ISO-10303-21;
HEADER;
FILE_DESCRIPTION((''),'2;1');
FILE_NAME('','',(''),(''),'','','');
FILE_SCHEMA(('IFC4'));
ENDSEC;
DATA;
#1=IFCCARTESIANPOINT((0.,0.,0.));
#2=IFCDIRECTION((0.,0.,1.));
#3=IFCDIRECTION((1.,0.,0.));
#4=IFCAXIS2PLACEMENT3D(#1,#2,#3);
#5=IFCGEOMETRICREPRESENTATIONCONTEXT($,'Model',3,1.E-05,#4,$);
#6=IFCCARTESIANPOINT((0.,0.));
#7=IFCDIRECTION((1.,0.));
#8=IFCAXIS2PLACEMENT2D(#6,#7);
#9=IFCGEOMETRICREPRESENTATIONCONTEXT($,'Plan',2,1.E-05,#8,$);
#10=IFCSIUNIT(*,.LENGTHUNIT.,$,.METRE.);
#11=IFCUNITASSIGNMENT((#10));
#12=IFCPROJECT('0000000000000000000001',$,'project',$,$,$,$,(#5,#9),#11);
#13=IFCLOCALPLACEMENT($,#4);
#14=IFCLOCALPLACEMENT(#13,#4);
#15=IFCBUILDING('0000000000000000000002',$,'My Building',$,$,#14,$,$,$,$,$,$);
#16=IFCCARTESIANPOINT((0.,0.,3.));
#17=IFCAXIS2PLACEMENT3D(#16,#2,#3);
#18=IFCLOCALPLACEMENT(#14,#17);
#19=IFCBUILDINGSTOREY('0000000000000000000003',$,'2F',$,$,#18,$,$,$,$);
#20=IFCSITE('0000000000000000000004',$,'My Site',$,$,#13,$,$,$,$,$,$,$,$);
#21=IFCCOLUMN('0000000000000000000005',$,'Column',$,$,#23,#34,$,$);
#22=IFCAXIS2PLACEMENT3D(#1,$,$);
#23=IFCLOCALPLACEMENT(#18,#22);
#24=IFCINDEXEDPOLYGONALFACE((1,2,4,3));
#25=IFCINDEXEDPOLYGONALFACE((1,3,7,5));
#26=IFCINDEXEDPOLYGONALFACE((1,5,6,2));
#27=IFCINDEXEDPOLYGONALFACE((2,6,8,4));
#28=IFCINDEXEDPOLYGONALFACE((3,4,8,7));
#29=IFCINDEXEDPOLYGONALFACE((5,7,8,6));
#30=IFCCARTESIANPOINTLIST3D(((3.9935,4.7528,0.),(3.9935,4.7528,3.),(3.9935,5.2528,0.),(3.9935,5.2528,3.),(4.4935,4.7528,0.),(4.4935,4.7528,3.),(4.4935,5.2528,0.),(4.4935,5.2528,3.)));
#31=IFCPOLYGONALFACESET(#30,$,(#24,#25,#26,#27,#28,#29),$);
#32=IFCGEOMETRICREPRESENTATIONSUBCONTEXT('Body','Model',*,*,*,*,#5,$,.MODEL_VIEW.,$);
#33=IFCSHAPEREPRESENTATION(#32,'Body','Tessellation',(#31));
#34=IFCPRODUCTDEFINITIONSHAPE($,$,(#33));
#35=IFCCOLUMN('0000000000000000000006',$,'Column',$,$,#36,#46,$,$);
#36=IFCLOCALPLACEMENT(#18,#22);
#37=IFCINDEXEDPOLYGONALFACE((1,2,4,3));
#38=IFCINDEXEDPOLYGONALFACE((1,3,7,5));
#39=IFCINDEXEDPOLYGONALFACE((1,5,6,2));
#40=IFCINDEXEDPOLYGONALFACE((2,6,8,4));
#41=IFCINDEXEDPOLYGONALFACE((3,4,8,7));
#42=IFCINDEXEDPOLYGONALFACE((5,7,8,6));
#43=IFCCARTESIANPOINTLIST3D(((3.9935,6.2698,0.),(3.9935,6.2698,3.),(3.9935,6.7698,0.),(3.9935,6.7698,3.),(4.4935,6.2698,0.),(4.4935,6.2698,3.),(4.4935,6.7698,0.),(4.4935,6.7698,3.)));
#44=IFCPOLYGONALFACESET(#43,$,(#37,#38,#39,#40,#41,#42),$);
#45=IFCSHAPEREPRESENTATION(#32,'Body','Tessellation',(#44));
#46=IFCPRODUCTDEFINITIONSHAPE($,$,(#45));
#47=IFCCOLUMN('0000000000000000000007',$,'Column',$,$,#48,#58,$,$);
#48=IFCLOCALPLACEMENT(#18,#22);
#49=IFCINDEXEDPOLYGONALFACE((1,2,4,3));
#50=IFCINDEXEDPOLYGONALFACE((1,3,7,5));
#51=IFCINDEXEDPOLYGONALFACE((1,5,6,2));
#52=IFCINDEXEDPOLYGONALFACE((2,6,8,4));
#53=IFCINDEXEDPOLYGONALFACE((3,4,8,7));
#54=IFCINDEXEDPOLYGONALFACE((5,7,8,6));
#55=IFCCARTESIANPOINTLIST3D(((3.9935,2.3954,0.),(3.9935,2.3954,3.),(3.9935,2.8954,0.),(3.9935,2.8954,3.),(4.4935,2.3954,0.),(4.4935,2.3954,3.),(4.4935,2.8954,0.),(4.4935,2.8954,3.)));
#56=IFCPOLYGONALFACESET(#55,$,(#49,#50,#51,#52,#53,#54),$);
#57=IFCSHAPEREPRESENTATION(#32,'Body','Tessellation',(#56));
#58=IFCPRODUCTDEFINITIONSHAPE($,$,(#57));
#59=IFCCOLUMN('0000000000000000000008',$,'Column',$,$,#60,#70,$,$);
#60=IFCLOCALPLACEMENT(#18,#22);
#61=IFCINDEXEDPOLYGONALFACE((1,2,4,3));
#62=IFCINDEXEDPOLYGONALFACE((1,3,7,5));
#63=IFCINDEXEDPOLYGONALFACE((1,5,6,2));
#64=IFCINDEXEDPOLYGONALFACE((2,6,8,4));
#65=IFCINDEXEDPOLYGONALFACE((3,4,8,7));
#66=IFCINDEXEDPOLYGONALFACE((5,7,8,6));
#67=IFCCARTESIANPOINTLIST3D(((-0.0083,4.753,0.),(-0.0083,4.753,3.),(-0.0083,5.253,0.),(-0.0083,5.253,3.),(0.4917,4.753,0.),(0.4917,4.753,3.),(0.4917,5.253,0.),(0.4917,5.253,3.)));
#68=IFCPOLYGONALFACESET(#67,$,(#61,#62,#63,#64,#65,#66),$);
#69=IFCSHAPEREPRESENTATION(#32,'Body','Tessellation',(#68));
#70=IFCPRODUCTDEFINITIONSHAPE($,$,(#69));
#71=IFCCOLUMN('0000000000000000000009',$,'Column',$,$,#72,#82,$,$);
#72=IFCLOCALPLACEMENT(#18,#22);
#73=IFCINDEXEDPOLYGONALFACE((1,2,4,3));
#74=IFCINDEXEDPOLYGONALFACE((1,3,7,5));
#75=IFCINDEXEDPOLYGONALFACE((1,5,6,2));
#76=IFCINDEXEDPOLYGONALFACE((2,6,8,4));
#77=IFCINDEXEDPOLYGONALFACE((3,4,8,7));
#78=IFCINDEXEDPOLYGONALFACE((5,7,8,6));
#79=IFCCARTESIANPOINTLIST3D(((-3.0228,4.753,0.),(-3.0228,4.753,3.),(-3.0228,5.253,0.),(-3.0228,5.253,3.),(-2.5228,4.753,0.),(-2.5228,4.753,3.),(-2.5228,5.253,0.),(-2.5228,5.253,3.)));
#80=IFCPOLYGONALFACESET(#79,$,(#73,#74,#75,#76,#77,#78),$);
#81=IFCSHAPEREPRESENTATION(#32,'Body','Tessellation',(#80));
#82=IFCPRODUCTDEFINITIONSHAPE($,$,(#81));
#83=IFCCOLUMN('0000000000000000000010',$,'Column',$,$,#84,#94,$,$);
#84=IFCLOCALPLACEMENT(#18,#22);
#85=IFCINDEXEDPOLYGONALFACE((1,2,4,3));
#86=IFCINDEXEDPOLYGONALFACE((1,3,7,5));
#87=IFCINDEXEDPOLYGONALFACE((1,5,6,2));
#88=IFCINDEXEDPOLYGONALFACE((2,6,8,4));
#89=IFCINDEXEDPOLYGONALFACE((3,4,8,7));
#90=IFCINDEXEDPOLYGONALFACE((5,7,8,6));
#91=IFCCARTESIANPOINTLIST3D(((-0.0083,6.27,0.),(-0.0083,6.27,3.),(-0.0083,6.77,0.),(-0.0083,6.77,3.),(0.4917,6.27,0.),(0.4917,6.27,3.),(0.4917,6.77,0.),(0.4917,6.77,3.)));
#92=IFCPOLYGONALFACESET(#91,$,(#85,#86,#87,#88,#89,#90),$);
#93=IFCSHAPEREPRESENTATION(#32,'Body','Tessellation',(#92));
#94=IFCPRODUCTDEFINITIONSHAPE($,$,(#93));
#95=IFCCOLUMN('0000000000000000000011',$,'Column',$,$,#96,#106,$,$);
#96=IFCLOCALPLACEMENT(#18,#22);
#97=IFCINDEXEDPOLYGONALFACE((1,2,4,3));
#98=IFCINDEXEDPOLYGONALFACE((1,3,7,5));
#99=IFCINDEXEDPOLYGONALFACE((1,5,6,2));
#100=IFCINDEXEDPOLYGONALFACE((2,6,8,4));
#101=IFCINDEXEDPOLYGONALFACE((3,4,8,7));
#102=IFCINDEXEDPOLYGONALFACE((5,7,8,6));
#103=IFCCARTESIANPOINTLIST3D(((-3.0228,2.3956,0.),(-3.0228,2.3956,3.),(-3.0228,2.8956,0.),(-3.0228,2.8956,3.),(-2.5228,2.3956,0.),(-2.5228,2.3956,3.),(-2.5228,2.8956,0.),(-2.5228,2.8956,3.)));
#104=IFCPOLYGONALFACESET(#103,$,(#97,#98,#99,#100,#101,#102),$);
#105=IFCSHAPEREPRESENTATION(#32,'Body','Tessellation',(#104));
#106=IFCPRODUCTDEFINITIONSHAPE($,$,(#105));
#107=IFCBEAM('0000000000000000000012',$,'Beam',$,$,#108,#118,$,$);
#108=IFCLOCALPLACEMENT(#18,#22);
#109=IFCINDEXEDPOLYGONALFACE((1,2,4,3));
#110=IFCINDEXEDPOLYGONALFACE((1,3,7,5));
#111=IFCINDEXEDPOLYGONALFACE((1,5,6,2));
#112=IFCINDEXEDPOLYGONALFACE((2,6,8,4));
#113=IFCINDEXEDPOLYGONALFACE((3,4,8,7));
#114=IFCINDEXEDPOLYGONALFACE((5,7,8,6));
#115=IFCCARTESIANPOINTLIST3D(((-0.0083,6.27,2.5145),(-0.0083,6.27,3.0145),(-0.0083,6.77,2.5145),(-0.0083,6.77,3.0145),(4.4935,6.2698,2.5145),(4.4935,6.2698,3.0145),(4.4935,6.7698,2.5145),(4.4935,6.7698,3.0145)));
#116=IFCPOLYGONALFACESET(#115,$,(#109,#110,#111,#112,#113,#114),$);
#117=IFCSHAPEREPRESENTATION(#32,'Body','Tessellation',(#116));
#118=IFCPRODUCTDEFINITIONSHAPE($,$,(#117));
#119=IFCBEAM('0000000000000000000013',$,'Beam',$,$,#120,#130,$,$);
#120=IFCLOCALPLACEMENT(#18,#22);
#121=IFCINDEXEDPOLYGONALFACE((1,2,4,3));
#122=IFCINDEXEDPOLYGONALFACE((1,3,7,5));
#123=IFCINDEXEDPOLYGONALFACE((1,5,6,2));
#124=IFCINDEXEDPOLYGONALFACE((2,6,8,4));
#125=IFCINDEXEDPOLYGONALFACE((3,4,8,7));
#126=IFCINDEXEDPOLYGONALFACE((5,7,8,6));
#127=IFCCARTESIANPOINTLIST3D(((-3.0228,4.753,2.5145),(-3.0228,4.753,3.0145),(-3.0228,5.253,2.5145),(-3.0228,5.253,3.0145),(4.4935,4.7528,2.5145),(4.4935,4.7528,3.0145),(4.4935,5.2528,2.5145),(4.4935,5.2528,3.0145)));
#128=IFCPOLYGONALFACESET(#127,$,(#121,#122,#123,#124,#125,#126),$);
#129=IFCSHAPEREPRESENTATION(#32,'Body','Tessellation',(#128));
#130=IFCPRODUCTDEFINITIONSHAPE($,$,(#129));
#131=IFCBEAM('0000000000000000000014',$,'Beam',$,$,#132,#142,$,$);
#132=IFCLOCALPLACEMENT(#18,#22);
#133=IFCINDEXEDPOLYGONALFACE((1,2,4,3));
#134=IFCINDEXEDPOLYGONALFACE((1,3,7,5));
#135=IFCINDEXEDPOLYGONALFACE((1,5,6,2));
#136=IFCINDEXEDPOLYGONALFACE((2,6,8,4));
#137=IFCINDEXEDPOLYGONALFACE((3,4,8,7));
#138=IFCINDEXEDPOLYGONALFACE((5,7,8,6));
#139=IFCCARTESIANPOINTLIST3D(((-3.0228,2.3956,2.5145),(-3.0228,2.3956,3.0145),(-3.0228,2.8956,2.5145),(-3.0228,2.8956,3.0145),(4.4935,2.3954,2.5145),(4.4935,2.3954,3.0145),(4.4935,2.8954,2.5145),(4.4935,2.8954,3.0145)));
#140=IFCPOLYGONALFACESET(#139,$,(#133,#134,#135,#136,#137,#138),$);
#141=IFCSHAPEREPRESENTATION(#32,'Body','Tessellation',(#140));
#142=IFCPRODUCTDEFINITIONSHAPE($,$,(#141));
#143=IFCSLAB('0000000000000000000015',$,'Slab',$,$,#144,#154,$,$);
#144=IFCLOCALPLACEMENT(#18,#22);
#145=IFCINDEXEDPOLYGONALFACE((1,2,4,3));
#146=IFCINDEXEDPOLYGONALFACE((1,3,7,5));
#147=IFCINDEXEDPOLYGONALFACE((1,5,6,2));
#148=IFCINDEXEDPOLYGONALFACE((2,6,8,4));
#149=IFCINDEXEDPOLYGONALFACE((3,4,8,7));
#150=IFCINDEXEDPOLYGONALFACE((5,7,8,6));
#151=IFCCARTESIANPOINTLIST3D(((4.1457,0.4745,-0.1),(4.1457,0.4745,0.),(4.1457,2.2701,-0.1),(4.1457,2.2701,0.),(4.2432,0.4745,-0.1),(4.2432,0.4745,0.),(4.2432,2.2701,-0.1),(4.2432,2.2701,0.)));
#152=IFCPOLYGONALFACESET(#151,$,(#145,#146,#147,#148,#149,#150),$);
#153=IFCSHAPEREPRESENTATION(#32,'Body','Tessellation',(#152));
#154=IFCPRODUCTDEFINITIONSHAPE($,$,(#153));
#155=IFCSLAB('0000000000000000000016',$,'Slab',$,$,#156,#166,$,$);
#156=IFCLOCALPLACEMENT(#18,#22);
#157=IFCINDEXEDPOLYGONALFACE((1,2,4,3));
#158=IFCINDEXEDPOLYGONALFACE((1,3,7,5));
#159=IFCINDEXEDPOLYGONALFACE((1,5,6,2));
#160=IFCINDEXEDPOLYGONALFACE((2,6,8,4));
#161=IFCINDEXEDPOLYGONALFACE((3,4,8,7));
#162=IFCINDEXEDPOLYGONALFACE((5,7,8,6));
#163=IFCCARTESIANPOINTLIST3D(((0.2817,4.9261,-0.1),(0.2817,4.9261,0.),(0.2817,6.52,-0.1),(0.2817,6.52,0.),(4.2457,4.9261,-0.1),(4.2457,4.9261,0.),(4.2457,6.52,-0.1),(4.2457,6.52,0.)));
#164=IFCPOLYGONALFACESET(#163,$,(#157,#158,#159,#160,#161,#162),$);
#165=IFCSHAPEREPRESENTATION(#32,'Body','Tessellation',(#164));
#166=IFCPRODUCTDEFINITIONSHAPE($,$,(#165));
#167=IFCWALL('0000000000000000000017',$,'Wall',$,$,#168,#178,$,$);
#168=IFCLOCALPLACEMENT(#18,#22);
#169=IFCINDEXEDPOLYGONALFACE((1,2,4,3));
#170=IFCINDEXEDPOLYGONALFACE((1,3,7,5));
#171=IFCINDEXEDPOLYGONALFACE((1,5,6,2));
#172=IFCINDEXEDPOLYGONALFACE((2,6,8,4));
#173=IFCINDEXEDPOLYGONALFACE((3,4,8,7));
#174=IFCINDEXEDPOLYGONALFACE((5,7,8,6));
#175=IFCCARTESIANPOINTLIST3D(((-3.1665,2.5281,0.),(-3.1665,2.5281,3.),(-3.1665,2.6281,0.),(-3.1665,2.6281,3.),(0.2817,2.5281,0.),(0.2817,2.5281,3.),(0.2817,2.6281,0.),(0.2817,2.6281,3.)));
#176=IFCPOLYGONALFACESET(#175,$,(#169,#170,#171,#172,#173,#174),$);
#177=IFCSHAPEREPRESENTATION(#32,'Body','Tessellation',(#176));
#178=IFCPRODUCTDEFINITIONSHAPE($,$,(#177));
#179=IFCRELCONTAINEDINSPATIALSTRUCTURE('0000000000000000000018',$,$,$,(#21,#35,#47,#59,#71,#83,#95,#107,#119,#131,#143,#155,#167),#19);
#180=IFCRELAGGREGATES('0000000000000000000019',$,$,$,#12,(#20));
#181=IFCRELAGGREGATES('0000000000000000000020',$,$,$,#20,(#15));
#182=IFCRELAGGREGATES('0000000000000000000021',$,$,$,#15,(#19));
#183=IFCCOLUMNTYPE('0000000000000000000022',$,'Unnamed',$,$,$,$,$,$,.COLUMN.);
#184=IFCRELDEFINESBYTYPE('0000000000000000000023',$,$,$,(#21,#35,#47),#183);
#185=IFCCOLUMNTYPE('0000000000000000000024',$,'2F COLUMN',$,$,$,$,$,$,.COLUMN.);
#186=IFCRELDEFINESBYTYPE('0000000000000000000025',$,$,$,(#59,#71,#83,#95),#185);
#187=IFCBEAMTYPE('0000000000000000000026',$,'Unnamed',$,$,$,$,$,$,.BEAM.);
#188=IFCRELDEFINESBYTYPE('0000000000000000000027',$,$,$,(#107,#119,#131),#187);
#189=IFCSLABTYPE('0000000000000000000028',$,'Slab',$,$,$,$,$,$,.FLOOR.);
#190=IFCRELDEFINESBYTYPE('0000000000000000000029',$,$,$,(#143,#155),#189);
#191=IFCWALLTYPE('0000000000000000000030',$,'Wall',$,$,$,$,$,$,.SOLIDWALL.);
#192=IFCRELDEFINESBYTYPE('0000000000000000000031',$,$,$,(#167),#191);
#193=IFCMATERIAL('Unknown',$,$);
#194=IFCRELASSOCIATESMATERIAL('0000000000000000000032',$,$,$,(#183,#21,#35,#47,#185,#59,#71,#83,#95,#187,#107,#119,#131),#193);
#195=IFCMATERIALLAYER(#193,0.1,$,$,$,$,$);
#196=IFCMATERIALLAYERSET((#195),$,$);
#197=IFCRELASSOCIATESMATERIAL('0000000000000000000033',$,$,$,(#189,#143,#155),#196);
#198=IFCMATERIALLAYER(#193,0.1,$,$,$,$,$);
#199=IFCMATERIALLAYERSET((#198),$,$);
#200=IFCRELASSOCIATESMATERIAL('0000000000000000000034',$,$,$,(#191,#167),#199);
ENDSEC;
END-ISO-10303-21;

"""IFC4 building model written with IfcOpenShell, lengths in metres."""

from ifc_helpers import new_model, si_unit, frame, origin_with_axes, origin_2d_with_axis, place, context, subcontext, project, spatial, line, indexed_curve, rectangle, outline, extrude, material, layer, layer_set, layer_usage, material_profile, profile_set, profile_usage, type_object, element, save


model = new_model("IFC4")

# Units and contexts
model_context = context("Model", 3, precision=1e-05, world=origin_with_axes())
plan_context = context("Plan", 2, precision=1e-05, world=origin_2d_with_axis())
body_context_1 = subcontext(model_context, "Body", "Model", "MODEL_VIEW")
ifc_project = project(units=[si_unit("LENGTHUNIT", "METRE")], contexts=[model_context, plan_context])

# Site, building, storey
site_placement = place(None, origin_with_axes())
site = spatial("IfcSite", under=ifc_project, at=site_placement, Name="My Site")
building_placement = place(site_placement, origin_with_axes())
building = spatial("IfcBuilding", under=site, at=building_placement, Name="My Building")
storey_placement = place(building_placement, frame((0.0, 0.0, 3.0), z_axis=(0.0, 0.0, 1.0), x_axis=(1.0, 0.0, 0.0)))
storey = spatial("IfcBuildingStorey", under=building, at=storey_placement, Name="2F")

# Columns
ifc_material = material(Name="Unknown")
ifc_material_profile_1 = material_profile(ifc_material, rectangle(XDim=0.5, YDim=0.5))
ifc_profile_set_1 = profile_set([ifc_material_profile_1])
ifc_profile_usage_1 = profile_usage(ifc_profile_set_1, cardinal=7)
column_type_1 = type_object("IfcColumnType", Name="Unnamed", PredefinedType="COLUMN", material=ifc_profile_set_1)
column_1_placement = place(storey_placement, frame((4.4935, 5.2528, 0.0), z_axis=(0.0, 0.0, 1.0), x_axis=(1.0, 0.0, 0.0)))
element("IfcColumn", 1, at=column_1_placement, inside=storey, type_object=column_type_1, material=ifc_profile_usage_1, Name="Column", context=body_context_1, shape_type="SweptSolid", body=[
    extrude(rectangle(XDim=0.5, YDim=0.5), frame((-0.25, -0.25, 0.0), z_axis=(0.0, 0.0, 1.0), x_axis=(1.0, 0.0, 0.0)), (0.0, 0.0, 1.0), 3.0),
])
ifc_profile_usage_2 = profile_usage(ifc_profile_set_1, cardinal=7)
column_2_placement = place(storey_placement, frame((4.4935, 6.7698, 0.0), z_axis=(0.0, 0.0, 1.0), x_axis=(1.0, 0.0, 0.0)))
element("IfcColumn", 2, at=column_2_placement, inside=storey, type_object=column_type_1, material=ifc_profile_usage_2, Name="Column", context=body_context_1, shape_type="SweptSolid", body=[
    extrude(rectangle(XDim=0.5, YDim=0.5), frame((-0.25, -0.25, 0.0), z_axis=(0.0, 0.0, 1.0), x_axis=(1.0, 0.0, 0.0)), (0.0, 0.0, 1.0), 3.0),
])
ifc_profile_usage_3 = profile_usage(ifc_profile_set_1, cardinal=7)
column_3_placement = place(storey_placement, frame((4.4935, 2.8954, 0.0), z_axis=(0.0, 0.0, 1.0), x_axis=(1.0, 0.0, 0.0)))
element("IfcColumn", 3, at=column_3_placement, inside=storey, type_object=column_type_1, material=ifc_profile_usage_3, Name="Column", context=body_context_1, shape_type="SweptSolid", body=[
    extrude(rectangle(XDim=0.5, YDim=0.5), frame((-0.25, -0.25, 0.0), z_axis=(0.0, 0.0, 1.0), x_axis=(1.0, 0.0, 0.0)), (0.0, 0.0, 1.0), 3.0),
])
ifc_material_profile_2 = material_profile(ifc_material, rectangle(XDim=0.5, YDim=0.5))
ifc_profile_set_2 = profile_set([ifc_material_profile_2])
ifc_profile_usage_4 = profile_usage(ifc_profile_set_2, cardinal=7)
column_type_2 = type_object("IfcColumnType", Name="2F COLUMN", PredefinedType="COLUMN", material=ifc_profile_set_2)
column_4_placement = place(storey_placement, frame((0.4917, 5.253, 0.0), z_axis=(0.0, 0.0, 1.0), x_axis=(1.0, 0.0, 0.0)))
element("IfcColumn", 4, at=column_4_placement, inside=storey, type_object=column_type_2, material=ifc_profile_usage_4, Name="Column", context=body_context_1, shape_type="SweptSolid", body=[
    extrude(rectangle(XDim=0.5, YDim=0.5), frame((-0.25, -0.25, 0.0), z_axis=(0.0, 0.0, 1.0), x_axis=(1.0, 0.0, 0.0)), (0.0, 0.0, 1.0), 3.0),
])
ifc_profile_usage_5 = profile_usage(ifc_profile_set_2, cardinal=7)
column_5_placement = place(storey_placement, frame((-2.5228, 5.253, 0.0), z_axis=(0.0, 0.0, 1.0), x_axis=(1.0, 0.0, 0.0)))
element("IfcColumn", 5, at=column_5_placement, inside=storey, type_object=column_type_2, material=ifc_profile_usage_5, Name="Column", context=body_context_1, shape_type="SweptSolid", body=[
    extrude(rectangle(XDim=0.5, YDim=0.5), frame((-0.25, -0.25, 0.0), z_axis=(0.0, 0.0, 1.0), x_axis=(1.0, 0.0, 0.0)), (0.0, 0.0, 1.0), 3.0),
])
ifc_profile_usage_6 = profile_usage(ifc_profile_set_2, cardinal=7)
column_6_placement = place(storey_placement, frame((0.4917, 6.77, 0.0), z_axis=(0.0, 0.0, 1.0), x_axis=(1.0, 0.0, 0.0)))
element("IfcColumn", 6, at=column_6_placement, inside=storey, type_object=column_type_2, material=ifc_profile_usage_6, Name="Column", context=body_context_1, shape_type="SweptSolid", body=[
    extrude(rectangle(XDim=0.5, YDim=0.5), frame((-0.25, -0.25, 0.0), z_axis=(0.0, 0.0, 1.0), x_axis=(1.0, 0.0, 0.0)), (0.0, 0.0, 1.0), 3.0),
])
ifc_profile_usage_7 = profile_usage(ifc_profile_set_2, cardinal=7)
column_7_placement = place(storey_placement, frame((-2.5228, 2.8956, 0.0), z_axis=(0.0, 0.0, 1.0), x_axis=(1.0, 0.0, 0.0)))
element("IfcColumn", 7, at=column_7_placement, inside=storey, type_object=column_type_2, material=ifc_profile_usage_7, Name="Column", context=body_context_1, shape_type="SweptSolid", body=[
    extrude(rectangle(XDim=0.5, YDim=0.5), frame((-0.25, -0.25, 0.0), z_axis=(0.0, 0.0, 1.0), x_axis=(1.0, 0.0, 0.0)), (0.0, 0.0, 1.0), 3.0),
])

# Beams
ifc_material_profile_3 = material_profile(ifc_material, rectangle(XDim=0.5, YDim=0.5))
ifc_profile_set_3 = profile_set([ifc_material_profile_3])
ifc_profile_usage_8 = profile_usage(ifc_profile_set_3, cardinal=7)
beam_type = type_object("IfcBeamType", Name="Unnamed", PredefinedType="BEAM", material=ifc_profile_set_3)
beam_1_placement = place(storey_placement, frame((-0.0083, 6.77, 3.0145), z_axis=(1.0, -0.000042, 0.0), x_axis=(0.000042, 1.0, 0.0)))
element("IfcBeam", 8, at=beam_1_placement, inside=storey, type_object=beam_type, material=ifc_profile_usage_8, Name="Beam", context=body_context_1, shape_type="SweptSolid", body=[
    extrude(rectangle(XDim=0.5, YDim=0.5), frame((-0.25, -0.25, 0.0), z_axis=(0.0, 0.0, 1.0), x_axis=(1.0, 0.0, 0.0)), (0.0, 0.0, 1.0), 4.5018),
])
ifc_profile_usage_9 = profile_usage(ifc_profile_set_3, cardinal=7)
beam_2_placement = place(storey_placement, frame((-3.0228, 5.253, 3.0145), z_axis=(1.0, -0.000025, 0.0), x_axis=(0.000025, 1.0, 0.0)))
element("IfcBeam", 9, at=beam_2_placement, inside=storey, type_object=beam_type, material=ifc_profile_usage_9, Name="Beam", context=body_context_1, shape_type="SweptSolid", body=[
    extrude(rectangle(XDim=0.5, YDim=0.5), frame((-0.25, -0.25, 0.0), z_axis=(0.0, 0.0, 1.0), x_axis=(1.0, 0.0, 0.0)), (0.0, 0.0, 1.0), 7.5163),
])
ifc_profile_usage_10 = profile_usage(ifc_profile_set_3, cardinal=7)
beam_3_placement = place(storey_placement, frame((-3.0228, 2.8956, 3.0145), z_axis=(1.0, -0.000025, 0.0), x_axis=(0.000025, 1.0, 0.0)))
element("IfcBeam", 10, at=beam_3_placement, inside=storey, type_object=beam_type, material=ifc_profile_usage_10, Name="Beam", context=body_context_1, shape_type="SweptSolid", body=[
    extrude(rectangle(XDim=0.5, YDim=0.5), frame((-0.25, -0.25, 0.0), z_axis=(0.0, 0.0, 1.0), x_axis=(1.0, 0.0, 0.0)), (0.0, 0.0, 1.0), 7.5163),
])

# Slabs
ifc_layer_1 = layer(ifc_material, 0.1)
ifc_layer_set_1 = layer_set([ifc_layer_1])
ifc_layer_usage_1 = layer_usage(ifc_layer_set_1, "AXIS3", "POSITIVE", -0.1)
slab_type = type_object("IfcSlabType", Name="Slab", PredefinedType="FLOOR", material=ifc_layer_set_1)
slab_1_placement = place(storey_placement, frame((4.1457, 0.4745, 0.0), z_axis=(0.0, 0.0, 1.0), x_axis=(1.0, 0.0, 0.0)))
element("IfcSlab", 11, at=slab_1_placement, inside=storey, type_object=slab_type, material=ifc_layer_usage_1, Name="Slab", context=body_context_1, shape_type="SweptSolid", body=[
    extrude(outline(indexed_curve([(0.0, 0.0), (0.0, 1.7956), (0.0975, 1.7956), (0.0975, -0.0001), (0.0, 0.0)])), frame((0.0, 0.0, -0.1), z_axis=(0.0, 0.0, 1.0), x_axis=(1.0, 0.0, 0.0)), (0.0, 0.0, 1.0), 0.1),
])
ifc_layer_usage_2 = layer_usage(ifc_layer_set_1, "AXIS3", "POSITIVE", -0.1)
slab_2_placement = place(storey_placement, frame((4.2457, 6.52, 0.0), z_axis=(0.0, 0.0, 1.0), x_axis=(1.0, 0.0, 0.0)))
element("IfcSlab", 12, at=slab_2_placement, inside=storey, type_object=slab_type, material=ifc_layer_usage_2, Name="Slab", context=body_context_1, shape_type="SweptSolid", body=[
    extrude(outline(indexed_curve([(0.0, 0.0), (-3.964, 0.0), (-3.964, -1.5939), (0.0, -1.5939), (0.0, 0.0)])), frame((0.0, 0.0, -0.1), z_axis=(0.0, 0.0, 1.0), x_axis=(1.0, 0.0, 0.0)), (0.0, 0.0, 1.0), 0.1),
])

# Wall
ifc_layer_2 = layer(ifc_material, 0.1)
ifc_layer_set_2 = layer_set([ifc_layer_2])
ifc_layer_usage_3 = layer_usage(ifc_layer_set_2, "AXIS2", "POSITIVE", 0.0)
wall_type_1 = type_object("IfcWallType", Name="Wall", PredefinedType="SOLIDWALL", material=ifc_layer_set_2)
wall_1_placement = place(storey_placement, frame((0.2817, 2.6281, 0.0), z_axis=(0.0, 0.0, 1.0), x_axis=(-1.0, 0.0, 0.0)))
element("IfcWall", 13, at=wall_1_placement, inside=storey, type_object=wall_type_1, material=ifc_layer_usage_3, Name="Wall", context=body_context_1, shape_type="SweptSolid", body=[
    extrude(outline(indexed_curve([(0.0, 0.0), (0.0, 0.1), (3.4482, 0.1), (3.4482, 0.0)], segments=[line(1, 2, 3, 4, 1)])), origin_with_axes(), (0.0, 0.0, 1.0), 3.0),
])

save(model, "model.ifc")
